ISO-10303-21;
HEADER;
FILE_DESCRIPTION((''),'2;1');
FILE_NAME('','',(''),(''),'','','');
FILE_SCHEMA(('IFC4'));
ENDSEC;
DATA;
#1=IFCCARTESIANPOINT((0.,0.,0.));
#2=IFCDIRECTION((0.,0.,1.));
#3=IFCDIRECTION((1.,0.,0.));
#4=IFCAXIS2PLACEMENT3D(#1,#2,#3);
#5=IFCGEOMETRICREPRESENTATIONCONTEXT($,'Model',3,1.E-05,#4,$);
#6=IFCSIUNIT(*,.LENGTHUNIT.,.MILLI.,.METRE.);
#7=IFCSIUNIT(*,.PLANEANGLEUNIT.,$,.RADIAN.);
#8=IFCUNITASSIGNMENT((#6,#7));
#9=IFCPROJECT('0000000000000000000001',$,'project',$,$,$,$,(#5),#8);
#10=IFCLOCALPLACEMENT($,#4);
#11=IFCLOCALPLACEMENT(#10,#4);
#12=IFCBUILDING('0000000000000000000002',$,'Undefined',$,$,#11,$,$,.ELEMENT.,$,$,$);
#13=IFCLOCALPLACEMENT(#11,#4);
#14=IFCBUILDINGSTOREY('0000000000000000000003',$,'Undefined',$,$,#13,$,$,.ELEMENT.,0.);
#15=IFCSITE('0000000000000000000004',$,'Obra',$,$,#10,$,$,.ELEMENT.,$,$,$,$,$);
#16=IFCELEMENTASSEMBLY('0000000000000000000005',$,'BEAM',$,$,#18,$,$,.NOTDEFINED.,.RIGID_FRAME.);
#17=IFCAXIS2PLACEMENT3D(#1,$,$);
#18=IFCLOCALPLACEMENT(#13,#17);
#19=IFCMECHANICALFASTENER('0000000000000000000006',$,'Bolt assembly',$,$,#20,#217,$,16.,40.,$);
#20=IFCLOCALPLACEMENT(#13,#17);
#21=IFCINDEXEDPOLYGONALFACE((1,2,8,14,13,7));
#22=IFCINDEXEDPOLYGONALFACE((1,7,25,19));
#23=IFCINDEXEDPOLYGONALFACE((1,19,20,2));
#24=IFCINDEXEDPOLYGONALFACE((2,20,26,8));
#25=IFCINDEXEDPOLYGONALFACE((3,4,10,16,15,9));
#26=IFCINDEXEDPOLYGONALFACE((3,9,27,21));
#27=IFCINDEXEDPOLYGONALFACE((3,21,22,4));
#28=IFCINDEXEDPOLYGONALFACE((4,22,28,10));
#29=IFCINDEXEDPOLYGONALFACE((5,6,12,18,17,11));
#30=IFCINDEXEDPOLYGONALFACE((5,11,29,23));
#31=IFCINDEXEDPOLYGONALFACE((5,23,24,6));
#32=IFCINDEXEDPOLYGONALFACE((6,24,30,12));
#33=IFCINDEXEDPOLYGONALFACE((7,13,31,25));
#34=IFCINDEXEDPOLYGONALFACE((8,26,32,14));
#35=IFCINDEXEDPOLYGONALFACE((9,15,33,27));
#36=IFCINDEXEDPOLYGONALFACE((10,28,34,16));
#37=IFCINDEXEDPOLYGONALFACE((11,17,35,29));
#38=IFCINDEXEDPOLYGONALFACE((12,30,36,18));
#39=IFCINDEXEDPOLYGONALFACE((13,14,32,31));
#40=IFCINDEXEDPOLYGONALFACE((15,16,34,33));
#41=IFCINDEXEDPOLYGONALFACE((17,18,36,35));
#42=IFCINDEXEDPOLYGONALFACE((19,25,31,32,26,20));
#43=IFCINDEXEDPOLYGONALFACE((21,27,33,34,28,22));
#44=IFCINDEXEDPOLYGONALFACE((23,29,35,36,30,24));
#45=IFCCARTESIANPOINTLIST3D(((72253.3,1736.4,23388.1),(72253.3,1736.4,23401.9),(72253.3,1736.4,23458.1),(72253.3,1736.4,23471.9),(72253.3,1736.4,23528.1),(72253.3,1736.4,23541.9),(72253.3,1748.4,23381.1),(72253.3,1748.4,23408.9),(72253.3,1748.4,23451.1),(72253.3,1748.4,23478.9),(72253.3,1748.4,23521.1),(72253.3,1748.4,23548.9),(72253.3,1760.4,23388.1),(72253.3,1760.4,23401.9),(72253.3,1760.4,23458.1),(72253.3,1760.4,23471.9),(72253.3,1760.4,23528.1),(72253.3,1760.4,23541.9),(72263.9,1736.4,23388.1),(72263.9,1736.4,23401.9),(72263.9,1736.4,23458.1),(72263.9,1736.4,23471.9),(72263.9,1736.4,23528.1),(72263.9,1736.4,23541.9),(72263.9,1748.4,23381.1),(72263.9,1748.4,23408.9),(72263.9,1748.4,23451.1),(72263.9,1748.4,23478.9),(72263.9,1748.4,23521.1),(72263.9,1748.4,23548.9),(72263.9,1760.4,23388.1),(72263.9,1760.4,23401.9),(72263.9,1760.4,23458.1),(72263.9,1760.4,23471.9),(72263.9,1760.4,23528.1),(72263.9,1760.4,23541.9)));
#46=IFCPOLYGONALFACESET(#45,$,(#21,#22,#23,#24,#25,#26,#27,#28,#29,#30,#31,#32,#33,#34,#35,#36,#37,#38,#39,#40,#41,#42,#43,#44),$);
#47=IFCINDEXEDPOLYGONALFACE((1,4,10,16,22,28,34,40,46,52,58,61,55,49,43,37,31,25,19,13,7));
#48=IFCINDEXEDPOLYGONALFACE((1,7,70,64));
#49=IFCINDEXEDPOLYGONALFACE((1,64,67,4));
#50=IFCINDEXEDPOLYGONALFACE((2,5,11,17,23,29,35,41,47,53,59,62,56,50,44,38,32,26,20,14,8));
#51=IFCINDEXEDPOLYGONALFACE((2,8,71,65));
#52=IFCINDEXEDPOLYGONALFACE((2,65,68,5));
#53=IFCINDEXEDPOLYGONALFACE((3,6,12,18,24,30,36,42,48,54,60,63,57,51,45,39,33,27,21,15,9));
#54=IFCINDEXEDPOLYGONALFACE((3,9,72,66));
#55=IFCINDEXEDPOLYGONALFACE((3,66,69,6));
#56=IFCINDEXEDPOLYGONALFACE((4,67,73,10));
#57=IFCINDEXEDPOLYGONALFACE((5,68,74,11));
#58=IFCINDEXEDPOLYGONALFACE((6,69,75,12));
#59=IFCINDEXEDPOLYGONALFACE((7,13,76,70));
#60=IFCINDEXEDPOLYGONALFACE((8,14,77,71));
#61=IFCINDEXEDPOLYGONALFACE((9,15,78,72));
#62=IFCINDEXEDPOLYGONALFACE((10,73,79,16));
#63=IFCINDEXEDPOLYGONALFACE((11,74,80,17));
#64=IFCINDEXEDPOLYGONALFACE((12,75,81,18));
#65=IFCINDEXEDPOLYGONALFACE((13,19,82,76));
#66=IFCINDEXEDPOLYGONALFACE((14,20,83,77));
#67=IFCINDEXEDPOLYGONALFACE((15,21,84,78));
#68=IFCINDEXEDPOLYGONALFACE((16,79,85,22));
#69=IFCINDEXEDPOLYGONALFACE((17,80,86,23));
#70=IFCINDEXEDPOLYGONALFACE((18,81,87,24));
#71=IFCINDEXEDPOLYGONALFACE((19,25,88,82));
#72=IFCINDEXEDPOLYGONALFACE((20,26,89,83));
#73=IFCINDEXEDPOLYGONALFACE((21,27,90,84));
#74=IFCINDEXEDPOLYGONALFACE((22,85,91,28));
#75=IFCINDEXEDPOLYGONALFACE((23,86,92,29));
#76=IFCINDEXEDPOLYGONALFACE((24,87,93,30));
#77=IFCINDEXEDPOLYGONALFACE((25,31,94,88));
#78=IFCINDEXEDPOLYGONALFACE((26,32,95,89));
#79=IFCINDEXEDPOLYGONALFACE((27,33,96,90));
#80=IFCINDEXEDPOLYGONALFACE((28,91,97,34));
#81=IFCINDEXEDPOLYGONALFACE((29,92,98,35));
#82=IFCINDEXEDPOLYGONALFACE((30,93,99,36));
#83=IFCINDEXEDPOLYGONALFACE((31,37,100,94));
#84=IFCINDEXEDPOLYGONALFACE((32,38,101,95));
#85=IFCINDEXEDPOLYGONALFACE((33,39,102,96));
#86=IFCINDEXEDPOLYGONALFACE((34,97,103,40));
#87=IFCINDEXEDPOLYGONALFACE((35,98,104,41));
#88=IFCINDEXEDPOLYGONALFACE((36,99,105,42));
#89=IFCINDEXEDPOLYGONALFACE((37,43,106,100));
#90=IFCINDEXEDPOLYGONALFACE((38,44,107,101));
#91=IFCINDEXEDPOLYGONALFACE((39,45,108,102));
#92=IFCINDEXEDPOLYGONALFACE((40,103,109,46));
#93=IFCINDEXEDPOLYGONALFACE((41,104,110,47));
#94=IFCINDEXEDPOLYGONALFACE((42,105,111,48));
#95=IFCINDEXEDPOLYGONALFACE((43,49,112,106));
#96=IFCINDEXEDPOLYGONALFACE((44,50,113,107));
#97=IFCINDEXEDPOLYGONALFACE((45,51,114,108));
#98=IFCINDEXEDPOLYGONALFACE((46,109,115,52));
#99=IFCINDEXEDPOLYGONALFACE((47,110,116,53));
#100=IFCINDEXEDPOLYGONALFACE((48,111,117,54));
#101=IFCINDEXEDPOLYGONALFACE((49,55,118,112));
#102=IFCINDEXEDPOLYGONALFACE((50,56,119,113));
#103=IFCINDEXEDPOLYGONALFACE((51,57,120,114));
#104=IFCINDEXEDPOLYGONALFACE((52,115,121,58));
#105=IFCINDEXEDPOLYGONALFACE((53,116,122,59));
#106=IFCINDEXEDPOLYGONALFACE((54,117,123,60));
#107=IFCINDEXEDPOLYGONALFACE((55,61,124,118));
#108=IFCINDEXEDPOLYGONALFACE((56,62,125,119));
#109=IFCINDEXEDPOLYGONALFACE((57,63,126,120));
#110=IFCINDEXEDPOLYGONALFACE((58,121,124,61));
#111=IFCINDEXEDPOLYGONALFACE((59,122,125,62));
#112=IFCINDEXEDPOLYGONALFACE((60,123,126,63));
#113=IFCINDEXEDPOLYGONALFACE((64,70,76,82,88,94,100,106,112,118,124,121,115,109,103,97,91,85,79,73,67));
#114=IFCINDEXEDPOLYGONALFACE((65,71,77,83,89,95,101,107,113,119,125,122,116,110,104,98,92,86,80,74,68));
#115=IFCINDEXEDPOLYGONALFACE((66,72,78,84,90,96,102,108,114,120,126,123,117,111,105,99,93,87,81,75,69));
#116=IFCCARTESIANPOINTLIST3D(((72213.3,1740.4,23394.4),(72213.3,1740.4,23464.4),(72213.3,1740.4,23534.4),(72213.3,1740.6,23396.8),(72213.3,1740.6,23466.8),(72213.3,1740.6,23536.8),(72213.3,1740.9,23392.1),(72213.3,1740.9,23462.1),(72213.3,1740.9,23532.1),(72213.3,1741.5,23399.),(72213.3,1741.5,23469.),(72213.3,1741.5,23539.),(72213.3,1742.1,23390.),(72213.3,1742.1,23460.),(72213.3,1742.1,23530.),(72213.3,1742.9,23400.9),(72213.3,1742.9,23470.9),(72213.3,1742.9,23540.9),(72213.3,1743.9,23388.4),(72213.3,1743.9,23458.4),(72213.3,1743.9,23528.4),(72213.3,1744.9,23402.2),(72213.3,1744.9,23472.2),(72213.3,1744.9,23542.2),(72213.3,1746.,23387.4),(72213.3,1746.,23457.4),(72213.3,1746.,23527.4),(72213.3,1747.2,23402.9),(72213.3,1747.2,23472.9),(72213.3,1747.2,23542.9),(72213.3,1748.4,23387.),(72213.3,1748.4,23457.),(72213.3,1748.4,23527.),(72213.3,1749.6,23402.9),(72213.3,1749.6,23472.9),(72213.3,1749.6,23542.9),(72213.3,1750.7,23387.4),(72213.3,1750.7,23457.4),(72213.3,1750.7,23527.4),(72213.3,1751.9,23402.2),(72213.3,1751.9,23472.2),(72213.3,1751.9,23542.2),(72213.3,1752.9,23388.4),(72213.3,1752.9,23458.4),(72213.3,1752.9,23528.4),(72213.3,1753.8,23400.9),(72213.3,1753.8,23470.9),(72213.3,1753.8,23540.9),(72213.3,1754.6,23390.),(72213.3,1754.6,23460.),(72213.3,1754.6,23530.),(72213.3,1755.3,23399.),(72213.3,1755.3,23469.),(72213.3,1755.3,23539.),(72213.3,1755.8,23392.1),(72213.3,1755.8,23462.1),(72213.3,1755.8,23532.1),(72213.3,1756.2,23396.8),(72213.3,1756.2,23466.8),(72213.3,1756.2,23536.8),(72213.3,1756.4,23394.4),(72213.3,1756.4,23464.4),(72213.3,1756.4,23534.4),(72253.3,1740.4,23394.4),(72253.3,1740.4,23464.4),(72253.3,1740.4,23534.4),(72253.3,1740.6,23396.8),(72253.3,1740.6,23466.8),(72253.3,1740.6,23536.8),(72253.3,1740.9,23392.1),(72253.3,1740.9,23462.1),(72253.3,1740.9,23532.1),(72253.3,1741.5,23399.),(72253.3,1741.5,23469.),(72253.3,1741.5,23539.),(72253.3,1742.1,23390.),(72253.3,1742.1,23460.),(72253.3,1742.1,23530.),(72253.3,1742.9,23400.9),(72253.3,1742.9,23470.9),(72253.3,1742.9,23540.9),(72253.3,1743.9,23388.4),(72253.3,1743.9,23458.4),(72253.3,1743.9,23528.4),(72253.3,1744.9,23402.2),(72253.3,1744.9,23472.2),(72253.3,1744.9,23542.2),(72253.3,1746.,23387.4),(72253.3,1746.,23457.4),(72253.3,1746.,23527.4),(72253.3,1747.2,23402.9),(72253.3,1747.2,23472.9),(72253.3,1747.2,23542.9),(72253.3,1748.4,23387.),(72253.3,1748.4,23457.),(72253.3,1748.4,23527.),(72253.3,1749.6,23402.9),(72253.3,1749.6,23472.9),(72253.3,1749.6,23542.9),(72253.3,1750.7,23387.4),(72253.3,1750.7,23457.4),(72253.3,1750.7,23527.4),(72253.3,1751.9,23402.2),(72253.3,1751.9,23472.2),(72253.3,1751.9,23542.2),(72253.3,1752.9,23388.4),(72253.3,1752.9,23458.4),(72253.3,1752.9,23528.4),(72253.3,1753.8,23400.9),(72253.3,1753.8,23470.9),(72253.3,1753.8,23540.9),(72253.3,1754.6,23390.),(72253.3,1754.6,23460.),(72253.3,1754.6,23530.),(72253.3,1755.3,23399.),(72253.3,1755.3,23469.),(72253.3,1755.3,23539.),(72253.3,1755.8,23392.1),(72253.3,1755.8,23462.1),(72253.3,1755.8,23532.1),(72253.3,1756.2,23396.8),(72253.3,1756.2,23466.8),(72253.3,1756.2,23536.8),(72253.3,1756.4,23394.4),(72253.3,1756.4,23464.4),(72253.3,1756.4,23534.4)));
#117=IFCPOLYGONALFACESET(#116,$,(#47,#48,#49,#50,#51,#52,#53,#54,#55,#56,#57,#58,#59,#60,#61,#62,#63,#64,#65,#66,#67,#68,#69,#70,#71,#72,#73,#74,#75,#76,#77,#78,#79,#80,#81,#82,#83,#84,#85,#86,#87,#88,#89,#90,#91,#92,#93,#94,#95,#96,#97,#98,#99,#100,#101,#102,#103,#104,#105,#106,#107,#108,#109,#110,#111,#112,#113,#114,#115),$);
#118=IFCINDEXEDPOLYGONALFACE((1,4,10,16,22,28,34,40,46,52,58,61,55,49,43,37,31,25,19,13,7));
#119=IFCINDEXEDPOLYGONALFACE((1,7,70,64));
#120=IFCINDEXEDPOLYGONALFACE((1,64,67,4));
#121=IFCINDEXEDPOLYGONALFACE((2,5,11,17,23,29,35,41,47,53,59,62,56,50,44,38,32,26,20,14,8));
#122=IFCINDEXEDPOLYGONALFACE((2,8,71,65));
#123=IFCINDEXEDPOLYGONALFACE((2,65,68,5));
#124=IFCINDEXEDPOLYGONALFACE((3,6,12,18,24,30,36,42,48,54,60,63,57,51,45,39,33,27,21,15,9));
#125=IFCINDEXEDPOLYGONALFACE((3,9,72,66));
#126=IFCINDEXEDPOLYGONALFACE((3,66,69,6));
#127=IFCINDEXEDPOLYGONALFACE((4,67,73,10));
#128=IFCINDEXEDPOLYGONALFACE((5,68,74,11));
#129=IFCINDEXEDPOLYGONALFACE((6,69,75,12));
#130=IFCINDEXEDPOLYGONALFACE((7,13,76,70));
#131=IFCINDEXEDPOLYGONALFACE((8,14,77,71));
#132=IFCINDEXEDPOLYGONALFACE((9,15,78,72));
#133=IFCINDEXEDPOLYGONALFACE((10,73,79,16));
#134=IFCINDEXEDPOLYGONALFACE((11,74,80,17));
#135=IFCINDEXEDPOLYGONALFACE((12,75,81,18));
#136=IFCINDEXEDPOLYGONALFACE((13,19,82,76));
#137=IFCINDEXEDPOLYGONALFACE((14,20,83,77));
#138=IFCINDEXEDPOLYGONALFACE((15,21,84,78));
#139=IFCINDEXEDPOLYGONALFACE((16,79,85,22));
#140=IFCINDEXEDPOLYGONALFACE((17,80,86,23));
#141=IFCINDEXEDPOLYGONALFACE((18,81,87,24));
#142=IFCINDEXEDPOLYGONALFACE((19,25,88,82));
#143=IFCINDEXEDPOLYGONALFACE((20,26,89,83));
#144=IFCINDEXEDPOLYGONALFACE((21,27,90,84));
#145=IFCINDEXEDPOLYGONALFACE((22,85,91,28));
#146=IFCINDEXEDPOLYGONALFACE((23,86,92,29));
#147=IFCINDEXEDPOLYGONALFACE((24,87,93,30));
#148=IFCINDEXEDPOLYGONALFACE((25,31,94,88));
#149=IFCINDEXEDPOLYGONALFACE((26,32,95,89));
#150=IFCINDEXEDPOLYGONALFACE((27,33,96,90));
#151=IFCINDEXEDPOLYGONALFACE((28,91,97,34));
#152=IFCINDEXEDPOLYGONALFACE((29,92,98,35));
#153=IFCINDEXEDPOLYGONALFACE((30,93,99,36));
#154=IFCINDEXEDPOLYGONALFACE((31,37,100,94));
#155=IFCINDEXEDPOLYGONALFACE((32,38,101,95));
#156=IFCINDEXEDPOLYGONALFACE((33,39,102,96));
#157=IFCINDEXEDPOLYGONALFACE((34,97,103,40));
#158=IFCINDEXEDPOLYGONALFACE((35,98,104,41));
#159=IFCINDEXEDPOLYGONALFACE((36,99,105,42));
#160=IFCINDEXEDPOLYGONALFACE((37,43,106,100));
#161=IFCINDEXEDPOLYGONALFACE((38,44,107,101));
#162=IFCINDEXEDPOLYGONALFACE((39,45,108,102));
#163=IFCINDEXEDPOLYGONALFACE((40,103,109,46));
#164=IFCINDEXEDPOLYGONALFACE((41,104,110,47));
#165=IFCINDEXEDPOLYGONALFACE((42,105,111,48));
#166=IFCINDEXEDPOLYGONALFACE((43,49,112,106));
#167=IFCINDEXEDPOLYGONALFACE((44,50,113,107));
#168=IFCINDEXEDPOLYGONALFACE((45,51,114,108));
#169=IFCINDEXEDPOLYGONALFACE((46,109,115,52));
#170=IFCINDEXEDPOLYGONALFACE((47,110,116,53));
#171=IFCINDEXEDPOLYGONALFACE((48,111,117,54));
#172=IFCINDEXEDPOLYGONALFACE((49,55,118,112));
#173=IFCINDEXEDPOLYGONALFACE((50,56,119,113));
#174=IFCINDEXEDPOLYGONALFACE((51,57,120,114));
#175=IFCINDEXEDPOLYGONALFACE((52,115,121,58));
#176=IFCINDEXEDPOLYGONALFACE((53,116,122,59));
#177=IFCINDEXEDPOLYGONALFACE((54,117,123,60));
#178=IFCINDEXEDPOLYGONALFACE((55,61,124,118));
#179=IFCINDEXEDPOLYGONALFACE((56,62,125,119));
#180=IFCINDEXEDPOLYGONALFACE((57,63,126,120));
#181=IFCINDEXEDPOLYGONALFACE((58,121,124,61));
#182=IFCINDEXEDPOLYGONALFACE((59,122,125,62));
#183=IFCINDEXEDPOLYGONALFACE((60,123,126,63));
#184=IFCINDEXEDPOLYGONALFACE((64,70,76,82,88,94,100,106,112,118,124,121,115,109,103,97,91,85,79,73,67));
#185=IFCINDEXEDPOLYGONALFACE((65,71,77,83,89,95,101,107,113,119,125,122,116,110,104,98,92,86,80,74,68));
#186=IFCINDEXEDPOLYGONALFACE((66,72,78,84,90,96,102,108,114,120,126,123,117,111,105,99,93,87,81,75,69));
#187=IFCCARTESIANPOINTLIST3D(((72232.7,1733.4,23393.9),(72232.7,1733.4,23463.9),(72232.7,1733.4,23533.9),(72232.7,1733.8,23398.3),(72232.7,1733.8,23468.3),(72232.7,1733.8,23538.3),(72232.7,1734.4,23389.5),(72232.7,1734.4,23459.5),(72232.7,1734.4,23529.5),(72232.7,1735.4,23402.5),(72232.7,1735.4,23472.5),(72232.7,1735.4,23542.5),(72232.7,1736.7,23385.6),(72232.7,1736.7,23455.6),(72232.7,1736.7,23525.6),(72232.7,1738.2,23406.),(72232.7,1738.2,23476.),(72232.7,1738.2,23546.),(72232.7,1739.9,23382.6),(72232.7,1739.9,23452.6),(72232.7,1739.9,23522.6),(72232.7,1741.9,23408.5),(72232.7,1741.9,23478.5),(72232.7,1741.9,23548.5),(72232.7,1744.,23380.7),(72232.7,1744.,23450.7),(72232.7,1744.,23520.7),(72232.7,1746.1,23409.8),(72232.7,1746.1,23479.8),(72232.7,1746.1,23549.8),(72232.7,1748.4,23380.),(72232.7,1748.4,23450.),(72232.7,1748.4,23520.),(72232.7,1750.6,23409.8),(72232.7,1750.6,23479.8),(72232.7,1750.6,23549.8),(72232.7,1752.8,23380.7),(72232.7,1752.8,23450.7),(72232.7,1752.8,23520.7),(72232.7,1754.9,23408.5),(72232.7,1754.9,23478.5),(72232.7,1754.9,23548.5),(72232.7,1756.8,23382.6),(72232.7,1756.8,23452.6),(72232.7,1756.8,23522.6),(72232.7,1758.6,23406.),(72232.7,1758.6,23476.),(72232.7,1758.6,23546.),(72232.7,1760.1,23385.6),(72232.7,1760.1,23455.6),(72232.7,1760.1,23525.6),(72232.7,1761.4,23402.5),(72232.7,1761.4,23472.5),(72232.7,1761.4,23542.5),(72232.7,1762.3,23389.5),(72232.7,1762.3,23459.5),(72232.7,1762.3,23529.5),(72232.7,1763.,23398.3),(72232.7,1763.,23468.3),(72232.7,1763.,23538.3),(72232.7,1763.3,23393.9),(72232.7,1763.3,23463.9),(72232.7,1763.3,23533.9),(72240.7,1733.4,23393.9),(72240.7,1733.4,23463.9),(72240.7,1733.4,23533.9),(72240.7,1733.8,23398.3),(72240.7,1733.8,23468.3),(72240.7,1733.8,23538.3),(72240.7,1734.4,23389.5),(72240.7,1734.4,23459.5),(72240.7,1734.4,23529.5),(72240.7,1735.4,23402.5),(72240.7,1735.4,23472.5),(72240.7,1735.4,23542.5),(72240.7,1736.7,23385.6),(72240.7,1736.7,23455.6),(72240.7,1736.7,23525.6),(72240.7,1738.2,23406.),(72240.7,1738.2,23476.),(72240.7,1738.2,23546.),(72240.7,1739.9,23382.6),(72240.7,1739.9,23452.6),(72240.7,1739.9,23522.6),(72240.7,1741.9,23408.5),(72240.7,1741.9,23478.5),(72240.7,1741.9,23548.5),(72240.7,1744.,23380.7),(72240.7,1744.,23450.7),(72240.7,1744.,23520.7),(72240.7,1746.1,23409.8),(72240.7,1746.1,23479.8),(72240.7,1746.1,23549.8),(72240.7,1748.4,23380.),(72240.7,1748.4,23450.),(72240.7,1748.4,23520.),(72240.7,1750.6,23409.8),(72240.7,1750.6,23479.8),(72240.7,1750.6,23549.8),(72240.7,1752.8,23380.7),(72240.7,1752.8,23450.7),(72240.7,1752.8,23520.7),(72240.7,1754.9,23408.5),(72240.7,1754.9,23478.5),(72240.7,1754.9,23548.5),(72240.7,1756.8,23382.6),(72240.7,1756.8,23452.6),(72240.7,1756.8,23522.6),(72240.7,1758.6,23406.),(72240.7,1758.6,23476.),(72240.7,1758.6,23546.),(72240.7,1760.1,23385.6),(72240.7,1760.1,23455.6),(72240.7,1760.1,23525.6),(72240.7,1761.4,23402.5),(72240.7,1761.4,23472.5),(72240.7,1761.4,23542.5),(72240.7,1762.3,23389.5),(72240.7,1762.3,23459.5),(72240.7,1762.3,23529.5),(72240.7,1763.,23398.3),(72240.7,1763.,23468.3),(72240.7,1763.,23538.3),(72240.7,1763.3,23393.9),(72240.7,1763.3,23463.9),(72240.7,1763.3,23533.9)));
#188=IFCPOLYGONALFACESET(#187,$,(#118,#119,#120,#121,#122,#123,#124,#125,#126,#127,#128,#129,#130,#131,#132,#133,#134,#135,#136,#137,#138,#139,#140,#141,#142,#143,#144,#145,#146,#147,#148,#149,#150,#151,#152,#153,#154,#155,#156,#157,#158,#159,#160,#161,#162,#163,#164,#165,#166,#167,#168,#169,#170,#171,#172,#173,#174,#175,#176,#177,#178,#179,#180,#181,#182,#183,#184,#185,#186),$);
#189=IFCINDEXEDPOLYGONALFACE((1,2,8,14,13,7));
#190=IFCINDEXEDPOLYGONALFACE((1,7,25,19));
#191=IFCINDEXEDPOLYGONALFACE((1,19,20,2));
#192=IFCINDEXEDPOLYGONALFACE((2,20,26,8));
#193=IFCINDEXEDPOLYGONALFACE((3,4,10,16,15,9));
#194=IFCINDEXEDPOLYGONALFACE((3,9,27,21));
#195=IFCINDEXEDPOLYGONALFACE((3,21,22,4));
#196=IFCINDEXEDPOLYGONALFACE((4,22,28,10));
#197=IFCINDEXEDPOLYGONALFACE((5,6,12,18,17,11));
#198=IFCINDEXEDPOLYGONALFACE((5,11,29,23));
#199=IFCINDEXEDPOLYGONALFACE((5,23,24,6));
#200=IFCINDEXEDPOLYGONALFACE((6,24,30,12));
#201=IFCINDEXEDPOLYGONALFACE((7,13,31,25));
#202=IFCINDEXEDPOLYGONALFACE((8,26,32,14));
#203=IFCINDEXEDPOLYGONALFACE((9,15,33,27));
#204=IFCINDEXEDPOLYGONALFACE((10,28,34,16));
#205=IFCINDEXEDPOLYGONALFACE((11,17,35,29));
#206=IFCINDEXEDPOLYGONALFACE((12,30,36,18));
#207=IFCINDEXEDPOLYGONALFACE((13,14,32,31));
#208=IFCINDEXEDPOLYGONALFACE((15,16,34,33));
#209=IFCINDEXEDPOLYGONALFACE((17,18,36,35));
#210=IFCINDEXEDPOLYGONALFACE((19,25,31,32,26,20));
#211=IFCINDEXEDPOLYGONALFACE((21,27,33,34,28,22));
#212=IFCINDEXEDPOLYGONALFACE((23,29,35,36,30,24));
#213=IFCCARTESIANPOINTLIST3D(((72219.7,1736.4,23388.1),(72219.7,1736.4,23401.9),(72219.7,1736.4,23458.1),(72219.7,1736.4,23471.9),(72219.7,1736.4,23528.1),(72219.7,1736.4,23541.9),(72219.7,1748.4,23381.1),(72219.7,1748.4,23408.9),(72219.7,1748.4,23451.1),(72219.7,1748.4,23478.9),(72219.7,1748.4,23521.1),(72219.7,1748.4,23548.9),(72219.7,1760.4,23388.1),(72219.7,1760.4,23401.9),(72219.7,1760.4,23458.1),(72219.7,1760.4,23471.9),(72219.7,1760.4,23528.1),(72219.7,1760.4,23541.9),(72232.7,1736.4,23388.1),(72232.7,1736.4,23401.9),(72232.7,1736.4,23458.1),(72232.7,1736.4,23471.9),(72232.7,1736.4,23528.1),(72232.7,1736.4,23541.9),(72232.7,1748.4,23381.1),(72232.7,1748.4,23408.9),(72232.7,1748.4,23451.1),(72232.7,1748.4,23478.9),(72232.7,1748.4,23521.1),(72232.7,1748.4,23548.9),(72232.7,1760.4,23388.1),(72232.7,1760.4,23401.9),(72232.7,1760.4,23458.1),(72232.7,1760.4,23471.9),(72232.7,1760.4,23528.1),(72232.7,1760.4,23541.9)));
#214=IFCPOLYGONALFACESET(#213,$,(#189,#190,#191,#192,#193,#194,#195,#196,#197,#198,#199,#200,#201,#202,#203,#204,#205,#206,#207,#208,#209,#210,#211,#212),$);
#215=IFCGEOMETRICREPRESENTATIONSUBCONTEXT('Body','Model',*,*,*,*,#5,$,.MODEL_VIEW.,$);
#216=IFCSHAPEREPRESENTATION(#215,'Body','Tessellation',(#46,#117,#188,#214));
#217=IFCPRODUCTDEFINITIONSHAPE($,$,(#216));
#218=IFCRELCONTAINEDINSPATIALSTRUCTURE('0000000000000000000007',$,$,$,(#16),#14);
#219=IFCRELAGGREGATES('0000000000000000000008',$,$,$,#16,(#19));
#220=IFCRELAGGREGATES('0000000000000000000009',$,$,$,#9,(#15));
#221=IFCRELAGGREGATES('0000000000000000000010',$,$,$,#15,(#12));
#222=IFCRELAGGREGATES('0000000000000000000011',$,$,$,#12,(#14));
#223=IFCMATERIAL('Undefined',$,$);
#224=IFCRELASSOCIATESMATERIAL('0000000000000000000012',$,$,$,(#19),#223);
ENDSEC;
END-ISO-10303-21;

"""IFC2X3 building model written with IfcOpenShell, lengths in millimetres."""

from ifc_helpers import new_model, si_unit, frame, origin_with_axes, origin_2d_with_axis, place, context, subcontext, project, spatial, polyline, circle, outline, extrude, source, transform, mapped, material, element, aggregate, save


model = new_model("IFC2X3")

# Units and contexts
model_context = context("Model", 3, precision=1e-05, world=origin_with_axes())
body_context = subcontext(model_context, "Body", "Model", "MODEL_VIEW")
ifc_project = project(units=[si_unit("LENGTHUNIT", "METRE", prefix="MILLI"), si_unit("PLANEANGLEUNIT", "RADIAN")], contexts=[model_context])

# Site, building, storey
site_placement = place(None, origin_with_axes())
site = spatial("IfcSite", under=ifc_project, at=site_placement, Name="Obra", CompositionType="ELEMENT")
building_placement = place(site_placement, origin_with_axes())
building = spatial("IfcBuilding", under=site, at=building_placement, Name="Undefined", CompositionType="ELEMENT")
storey_placement = place(building_placement, origin_with_axes())
storey = spatial("IfcBuildingStorey", under=building, at=storey_placement, Name="Undefined", CompositionType="ELEMENT", Elevation=0.0)

# Element assembly
assembly_1_placement = place(storey_placement, origin_with_axes())
assembly_1 = element("IfcElementAssembly", 1, at=assembly_1_placement, inside=storey, Name="BEAM", AssemblyPlace="NOTDEFINED", PredefinedType="RIGID_FRAME")

# Shared definitions
ifc_material_1 = material(Name="Undefined")

# Mechanical fastener
shared_shape_1 = source(origin_with_axes(), body_context, "Body", "SweptSolid", [
    extrude(outline(polyline([(13.9, 0.0), (6.9, 12.0), (-6.9, 12.0), (-13.9, 0.0), (-6.9, -12.0), (6.9, -12.0), (13.9, 0.0)])), frame((0.0, -13.9, 0.0), z_axis=(0.0, 1.0, 0.0), x_axis=(1.0, 0.0, 0.0)), (0.0, 0.0, 1.0), 10.6),
    extrude(circle(Radius=8.0, at=origin_2d_with_axis()), frame((0.0, -3.3, 0.0), z_axis=(0.0, 1.0, 0.0), x_axis=(1.0, 0.0, 0.0)), (0.0, 0.0, 1.0), 40.0),
    extrude(circle(Radius=15.0, at=origin_2d_with_axis()), frame((0.0, 9.3, 0.0), z_axis=(0.0, 1.0, 0.0), x_axis=(1.0, 0.0, 0.0)), (0.0, 0.0, 1.0), 8.0),
    extrude(outline(polyline([(13.9, 0.0), (6.9, 12.0), (-6.9, 12.0), (-13.9, 0.0), (-6.9, -12.0), (6.9, -12.0), (13.9, 0.0)])), frame((0.0, 17.3, 0.0), z_axis=(0.0, 1.0, 0.0), x_axis=(1.0, 0.0, 0.0)), (0.0, 0.0, 1.0), 13.0),
])
mechanical_fastener_1_placement = place(assembly_1_placement, frame((72250.0, 1708.4, 23570.0), z_axis=(0.0, 1.0, 0.0), x_axis=(0.0, 0.0, -1.0)))
mechanical_fastener_1 = element("IfcMechanicalFastener", 2, at=mechanical_fastener_1_placement, material=ifc_material_1, Name="Bolt assembly", NominalDiameter=16.0, NominalLength=40.0, context=body_context, shape_type="MappedRepresentation", body=[
    mapped(shared_shape_1, transform((35.0, 0.0, 40.0))),
    mapped(shared_shape_1, transform((105.0, 0.0, 40.0))),
    mapped(shared_shape_1, transform((175.0, 0.0, 40.0))),
])
aggregate(assembly_1, [mechanical_fastener_1])

save(model, "model.ifc")
